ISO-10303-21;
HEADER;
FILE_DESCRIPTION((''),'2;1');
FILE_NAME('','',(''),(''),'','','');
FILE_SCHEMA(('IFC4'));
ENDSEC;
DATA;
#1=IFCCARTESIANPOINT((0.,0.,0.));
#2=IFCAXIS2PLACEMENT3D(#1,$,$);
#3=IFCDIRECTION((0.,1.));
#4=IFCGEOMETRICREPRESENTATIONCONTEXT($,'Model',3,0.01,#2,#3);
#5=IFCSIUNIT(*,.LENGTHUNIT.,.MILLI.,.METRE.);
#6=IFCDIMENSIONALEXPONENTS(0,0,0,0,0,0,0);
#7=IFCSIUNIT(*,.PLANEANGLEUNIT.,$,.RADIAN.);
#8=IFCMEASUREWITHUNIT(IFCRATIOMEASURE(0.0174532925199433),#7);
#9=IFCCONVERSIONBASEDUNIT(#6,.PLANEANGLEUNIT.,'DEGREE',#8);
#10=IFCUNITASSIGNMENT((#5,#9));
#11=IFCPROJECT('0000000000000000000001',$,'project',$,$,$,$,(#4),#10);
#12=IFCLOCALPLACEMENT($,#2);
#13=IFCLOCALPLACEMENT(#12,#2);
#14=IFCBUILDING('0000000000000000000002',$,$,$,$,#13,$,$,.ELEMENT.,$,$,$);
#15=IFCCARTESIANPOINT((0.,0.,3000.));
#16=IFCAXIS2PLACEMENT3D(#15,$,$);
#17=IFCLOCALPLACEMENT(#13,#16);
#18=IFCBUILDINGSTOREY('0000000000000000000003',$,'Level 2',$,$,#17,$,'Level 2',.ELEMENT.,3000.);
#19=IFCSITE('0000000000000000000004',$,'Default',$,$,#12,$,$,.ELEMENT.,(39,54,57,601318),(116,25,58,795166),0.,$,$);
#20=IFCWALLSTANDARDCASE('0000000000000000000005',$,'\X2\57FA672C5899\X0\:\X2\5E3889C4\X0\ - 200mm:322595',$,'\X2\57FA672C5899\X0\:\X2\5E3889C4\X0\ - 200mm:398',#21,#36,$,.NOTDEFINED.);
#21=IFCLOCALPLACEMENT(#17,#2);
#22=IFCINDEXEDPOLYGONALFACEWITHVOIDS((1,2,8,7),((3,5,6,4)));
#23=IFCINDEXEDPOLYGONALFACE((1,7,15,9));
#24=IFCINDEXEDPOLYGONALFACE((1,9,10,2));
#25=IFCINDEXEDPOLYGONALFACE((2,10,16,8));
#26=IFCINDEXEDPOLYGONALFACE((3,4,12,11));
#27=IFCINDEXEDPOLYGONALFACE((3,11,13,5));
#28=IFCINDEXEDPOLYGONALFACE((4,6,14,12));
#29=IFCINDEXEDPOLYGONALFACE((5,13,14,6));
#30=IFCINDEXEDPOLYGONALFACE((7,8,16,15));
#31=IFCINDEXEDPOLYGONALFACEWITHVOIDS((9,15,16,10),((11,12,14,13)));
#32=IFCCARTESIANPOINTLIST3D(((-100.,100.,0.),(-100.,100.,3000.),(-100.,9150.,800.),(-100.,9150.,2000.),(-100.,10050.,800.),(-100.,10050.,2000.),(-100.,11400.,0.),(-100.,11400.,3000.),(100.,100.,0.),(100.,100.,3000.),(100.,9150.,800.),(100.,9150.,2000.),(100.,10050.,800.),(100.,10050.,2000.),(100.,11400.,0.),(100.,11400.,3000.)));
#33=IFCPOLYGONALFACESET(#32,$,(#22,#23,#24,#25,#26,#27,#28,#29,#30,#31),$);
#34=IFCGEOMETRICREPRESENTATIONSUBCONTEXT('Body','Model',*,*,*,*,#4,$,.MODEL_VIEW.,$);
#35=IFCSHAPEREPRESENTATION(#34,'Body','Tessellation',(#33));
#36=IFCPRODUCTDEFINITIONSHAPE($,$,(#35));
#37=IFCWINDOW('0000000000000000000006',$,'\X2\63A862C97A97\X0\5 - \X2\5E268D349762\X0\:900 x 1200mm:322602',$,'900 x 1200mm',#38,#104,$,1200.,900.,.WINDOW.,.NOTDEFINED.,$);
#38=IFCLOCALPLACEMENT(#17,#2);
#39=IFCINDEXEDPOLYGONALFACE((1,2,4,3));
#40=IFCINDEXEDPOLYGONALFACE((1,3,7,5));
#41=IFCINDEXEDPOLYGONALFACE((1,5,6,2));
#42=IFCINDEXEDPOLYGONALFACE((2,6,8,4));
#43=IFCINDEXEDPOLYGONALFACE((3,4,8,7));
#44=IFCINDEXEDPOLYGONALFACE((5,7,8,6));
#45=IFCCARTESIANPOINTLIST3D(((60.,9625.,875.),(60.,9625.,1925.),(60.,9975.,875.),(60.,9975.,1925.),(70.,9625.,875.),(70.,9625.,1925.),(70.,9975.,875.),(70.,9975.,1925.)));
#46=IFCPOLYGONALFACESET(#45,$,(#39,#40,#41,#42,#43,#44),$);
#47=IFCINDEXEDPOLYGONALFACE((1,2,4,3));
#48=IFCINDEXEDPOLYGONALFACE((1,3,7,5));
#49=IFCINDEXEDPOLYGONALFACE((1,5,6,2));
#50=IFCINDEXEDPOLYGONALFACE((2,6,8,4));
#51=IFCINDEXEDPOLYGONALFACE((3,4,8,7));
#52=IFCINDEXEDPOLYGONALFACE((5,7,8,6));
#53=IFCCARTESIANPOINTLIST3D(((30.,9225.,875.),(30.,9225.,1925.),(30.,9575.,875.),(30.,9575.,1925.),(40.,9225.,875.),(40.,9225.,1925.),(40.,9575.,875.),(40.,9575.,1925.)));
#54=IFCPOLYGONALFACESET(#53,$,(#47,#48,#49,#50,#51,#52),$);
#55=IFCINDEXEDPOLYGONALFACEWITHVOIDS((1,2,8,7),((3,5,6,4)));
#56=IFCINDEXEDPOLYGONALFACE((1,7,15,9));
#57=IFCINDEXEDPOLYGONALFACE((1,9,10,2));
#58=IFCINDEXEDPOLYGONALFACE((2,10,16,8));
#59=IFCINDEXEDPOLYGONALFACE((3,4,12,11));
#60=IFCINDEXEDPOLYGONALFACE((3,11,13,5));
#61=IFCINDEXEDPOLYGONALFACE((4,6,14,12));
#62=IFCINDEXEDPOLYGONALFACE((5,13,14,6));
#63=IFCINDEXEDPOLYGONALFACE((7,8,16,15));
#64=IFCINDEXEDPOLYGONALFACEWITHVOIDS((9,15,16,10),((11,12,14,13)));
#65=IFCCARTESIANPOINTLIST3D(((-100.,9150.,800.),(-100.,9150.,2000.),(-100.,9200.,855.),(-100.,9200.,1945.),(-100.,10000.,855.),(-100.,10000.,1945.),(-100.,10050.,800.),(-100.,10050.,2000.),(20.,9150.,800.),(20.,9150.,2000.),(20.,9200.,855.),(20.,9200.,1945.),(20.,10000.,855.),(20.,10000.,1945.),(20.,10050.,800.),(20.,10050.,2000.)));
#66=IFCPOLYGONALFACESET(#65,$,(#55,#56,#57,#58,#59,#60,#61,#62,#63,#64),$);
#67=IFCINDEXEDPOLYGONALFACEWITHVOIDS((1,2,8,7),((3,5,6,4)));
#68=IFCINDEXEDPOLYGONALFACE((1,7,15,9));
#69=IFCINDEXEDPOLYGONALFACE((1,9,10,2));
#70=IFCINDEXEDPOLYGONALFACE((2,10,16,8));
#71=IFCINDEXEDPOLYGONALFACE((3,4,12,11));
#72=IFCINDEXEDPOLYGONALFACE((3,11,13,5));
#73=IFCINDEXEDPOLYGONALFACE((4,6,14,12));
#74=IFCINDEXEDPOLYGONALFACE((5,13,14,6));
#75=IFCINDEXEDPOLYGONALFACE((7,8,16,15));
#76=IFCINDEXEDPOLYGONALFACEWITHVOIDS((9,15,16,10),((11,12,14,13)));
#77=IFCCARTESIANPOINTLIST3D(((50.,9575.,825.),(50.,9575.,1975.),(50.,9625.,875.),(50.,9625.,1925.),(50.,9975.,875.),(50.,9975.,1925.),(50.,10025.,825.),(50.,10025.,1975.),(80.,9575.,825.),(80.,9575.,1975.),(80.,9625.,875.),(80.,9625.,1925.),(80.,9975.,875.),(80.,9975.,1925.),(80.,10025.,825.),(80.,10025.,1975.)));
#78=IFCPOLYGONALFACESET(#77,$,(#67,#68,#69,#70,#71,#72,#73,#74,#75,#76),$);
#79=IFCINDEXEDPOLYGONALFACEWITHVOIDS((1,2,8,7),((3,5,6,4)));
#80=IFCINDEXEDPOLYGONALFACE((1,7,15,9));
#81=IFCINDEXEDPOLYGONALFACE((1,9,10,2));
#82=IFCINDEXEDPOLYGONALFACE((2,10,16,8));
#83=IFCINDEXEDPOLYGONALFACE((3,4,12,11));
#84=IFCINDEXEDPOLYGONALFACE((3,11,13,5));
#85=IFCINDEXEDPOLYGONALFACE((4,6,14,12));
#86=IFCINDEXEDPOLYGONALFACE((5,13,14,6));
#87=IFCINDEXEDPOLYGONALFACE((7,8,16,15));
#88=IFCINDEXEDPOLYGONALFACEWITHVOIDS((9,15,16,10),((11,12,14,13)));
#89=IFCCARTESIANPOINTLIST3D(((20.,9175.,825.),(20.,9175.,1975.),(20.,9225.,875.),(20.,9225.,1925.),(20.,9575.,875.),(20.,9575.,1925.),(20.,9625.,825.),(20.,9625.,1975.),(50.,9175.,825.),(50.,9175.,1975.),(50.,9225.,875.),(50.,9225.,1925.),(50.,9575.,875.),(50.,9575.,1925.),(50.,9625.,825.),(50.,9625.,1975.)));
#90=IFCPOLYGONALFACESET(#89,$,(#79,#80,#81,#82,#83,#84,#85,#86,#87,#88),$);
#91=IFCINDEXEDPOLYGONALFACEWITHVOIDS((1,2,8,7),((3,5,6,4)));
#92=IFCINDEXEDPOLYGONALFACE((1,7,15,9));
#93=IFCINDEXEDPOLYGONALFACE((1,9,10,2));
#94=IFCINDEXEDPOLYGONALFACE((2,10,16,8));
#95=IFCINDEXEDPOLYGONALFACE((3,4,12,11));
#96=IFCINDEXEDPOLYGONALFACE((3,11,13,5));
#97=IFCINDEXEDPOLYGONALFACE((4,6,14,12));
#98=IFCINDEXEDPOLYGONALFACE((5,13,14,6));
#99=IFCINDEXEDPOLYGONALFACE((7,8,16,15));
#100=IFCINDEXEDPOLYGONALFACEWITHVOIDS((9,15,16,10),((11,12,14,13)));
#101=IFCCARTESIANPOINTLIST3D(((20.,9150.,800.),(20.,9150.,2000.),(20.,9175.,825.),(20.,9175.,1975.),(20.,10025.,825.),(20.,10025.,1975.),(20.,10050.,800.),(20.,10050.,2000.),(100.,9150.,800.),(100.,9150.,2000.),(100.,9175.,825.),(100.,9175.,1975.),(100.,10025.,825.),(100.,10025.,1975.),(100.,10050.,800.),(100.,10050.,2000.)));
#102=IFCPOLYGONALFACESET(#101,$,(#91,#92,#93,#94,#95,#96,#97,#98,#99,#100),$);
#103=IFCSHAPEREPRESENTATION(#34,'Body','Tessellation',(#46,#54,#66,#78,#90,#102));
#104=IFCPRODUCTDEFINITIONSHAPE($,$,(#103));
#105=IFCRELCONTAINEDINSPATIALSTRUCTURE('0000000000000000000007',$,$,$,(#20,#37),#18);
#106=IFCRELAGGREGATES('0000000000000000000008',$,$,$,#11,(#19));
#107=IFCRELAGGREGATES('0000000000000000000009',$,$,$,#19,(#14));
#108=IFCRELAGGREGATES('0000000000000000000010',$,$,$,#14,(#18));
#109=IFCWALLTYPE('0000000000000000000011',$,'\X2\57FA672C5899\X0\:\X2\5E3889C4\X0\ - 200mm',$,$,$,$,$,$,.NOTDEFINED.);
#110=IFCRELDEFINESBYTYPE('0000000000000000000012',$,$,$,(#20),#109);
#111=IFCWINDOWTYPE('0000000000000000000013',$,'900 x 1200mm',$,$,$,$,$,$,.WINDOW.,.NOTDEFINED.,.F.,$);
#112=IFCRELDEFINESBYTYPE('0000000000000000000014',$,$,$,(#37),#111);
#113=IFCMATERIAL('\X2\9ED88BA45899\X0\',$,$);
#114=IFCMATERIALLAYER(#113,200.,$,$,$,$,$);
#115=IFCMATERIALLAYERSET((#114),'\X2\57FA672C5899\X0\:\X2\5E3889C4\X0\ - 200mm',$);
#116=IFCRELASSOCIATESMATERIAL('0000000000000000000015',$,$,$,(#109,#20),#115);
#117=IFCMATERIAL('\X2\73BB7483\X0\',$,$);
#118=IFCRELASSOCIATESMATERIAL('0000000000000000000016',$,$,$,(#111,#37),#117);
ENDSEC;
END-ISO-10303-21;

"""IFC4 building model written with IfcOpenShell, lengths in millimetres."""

from ifc_helpers import new_model, entity, si_unit, converted_unit, direction, frame, frame_2d, origin, origin_2d_with_axis, place, context, subcontext, project, spatial, polyline, rectangle, outline, extrude, source, transform, mapped, material, layer, layer_set, layer_usage, type_object, type_shapes, element, fill, save


model = new_model("IFC4")

# Units and contexts
model_context = context("Model", 3, precision=0.01, world=origin(), true_north=direction((0.0, 1.0)))
body_context = subcontext(model_context, "Body", "Model", "MODEL_VIEW")
ifc_project = project(units=[si_unit("LENGTHUNIT", "METRE", prefix="MILLI"), converted_unit("PLANEANGLEUNIT", "DEGREE", entity("IfcRatioMeasure", 0.0174532925199433), si_unit("PLANEANGLEUNIT", "RADIAN"), dimensions=[0, 0, 0, 0, 0, 0, 0])], contexts=[model_context])

# Site, building, storey
site_placement = place(None, origin())
site = spatial("IfcSite", under=ifc_project, at=site_placement, Name="Default", CompositionType="ELEMENT", RefLatitude=(39, 54, 57, 601318), RefLongitude=(116, 25, 58, 795166), RefElevation=0.0)
building_placement = place(site_placement, origin())
building = spatial("IfcBuilding", under=site, at=building_placement, CompositionType="ELEMENT")
storey_placement = place(building_placement, frame((0.0, 0.0, 3000.0)))
storey = spatial("IfcBuildingStorey", under=building, at=storey_placement, Name="Level 2", LongName="Level 2", CompositionType="ELEMENT", Elevation=3000.0)

# Shared definitions
ifc_material_1 = material(Name="默认墙")
ifc_layer_1 = layer(ifc_material_1, 200.0)
ifc_layer_set_1 = layer_set([ifc_layer_1], Name="基本墙:常规 - 200mm")
wall_type = type_object("IfcWallType", Name="基本墙:常规 - 200mm", PredefinedType="NOTDEFINED", material=ifc_layer_set_1)

# Shared definitions
ifc_material_2 = material(Name="玻璃")
window_type_1 = type_object("IfcWindowType", Name="900 x 1200mm", ParameterTakesPrecedence=False, PartitioningType="NOTDEFINED", PredefinedType="WINDOW", material=ifc_material_2)
shared_shape_1 = source(origin(), body_context, "Body", "SweptSolid", [
    extrude(rectangle(XDim=10.0, YDim=350.0, at=origin_2d_with_axis()), frame((250.0, 165.0, 75.0), z_axis=(0.0, 0.0, 1.0), x_axis=(0.0, -1.0, 0.0)), (0.0, 0.0, 1.0), 1050.0),
    extrude(rectangle(XDim=10.0, YDim=350.0, at=origin_2d_with_axis()), frame((650.0, 135.0, 75.0), z_axis=(0.0, 0.0, 1.0), x_axis=(0.0, -1.0, 0.0)), (0.0, 0.0, 1.0), 1050.0),
    extrude(outline(polyline([(-450.0, -600.0), (450.0, -600.0), (450.0, 600.0), (-450.0, 600.0), (-450.0, -600.0)]), holes=[polyline([(400.0, -545.0), (-400.0, -545.0), (-400.0, 545.0), (400.0, 545.0), (400.0, -545.0)])]), frame((450.0, 0.0, 600.0), z_axis=(0.0, 1.0, 0.0), x_axis=(1.0, 0.0, 0.0)), (0.0, 0.0, 1.0), 120.0),
    extrude(outline(polyline([(-225.0, -575.0), (225.0, -575.0), (225.0, 575.0), (-225.0, 575.0), (-225.0, -575.0)]), holes=[polyline([(-175.0, -525.0), (-175.0, 525.0), (175.0, 525.0), (175.0, -525.0), (-175.0, -525.0)])]), frame((250.0, 150.0, 600.0), z_axis=(0.0, 1.0, 0.0), x_axis=(-1.0, 0.0, 0.0)), (0.0, 0.0, 1.0), 30.0),
    extrude(outline(polyline([(-225.0, -575.0), (225.0, -575.0), (225.0, 575.0), (-225.0, 575.0), (-225.0, -575.0)]), holes=[polyline([(-175.0, -525.0), (-175.0, 525.0), (175.0, 525.0), (175.0, -525.0), (-175.0, -525.0)])]), frame((650.0, 120.0, 600.0), z_axis=(0.0, 1.0, 0.0), x_axis=(1.0, 0.0, 0.0)), (0.0, 0.0, 1.0), 30.0),
    extrude(outline(polyline([(-450.0, -600.0), (450.0, -600.0), (450.0, 600.0), (-450.0, 600.0), (-450.0, -600.0)]), holes=[polyline([(-425.0, 575.0), (425.0, 575.0), (425.0, -575.0), (-425.0, -575.0), (-425.0, 575.0)])]), frame((450.0, 120.0, 600.0), z_axis=(0.0, 1.0, 0.0), x_axis=(1.0, 0.0, 0.0)), (0.0, 0.0, 1.0), 80.0),
])
type_shapes(window_type_1, [shared_shape_1])

# Wall, opening, window
ifc_layer_usage_1 = layer_usage(ifc_layer_set_1, "AXIS2", "NEGATIVE", 100.0)
wall_1_placement = place(storey_placement, frame((0.0, 100.0, 0.0), z_axis=(0.0, 0.0, 1.0), x_axis=(0.0, 1.0, 0.0)))
wall_1 = element("IfcWallStandardCase", 1, at=wall_1_placement, inside=storey, type_object=wall_type, material=ifc_layer_usage_1, Name="基本墙:常规 - 200mm:322595", ObjectType="基本墙:常规 - 200mm:398", PredefinedType="NOTDEFINED", context=body_context, shape_type="SweptSolid", body=[
    extrude(rectangle(XDim=11300.0, YDim=200.0, at=frame_2d((5650.0, 0.0), x_axis=(-1.0, 0.0))), origin(), (0.0, 0.0, 1.0), 3000.0),
])
opening_1_placement = place(wall_1_placement, frame((9950.0, 100.0, 800.0)))
opening_1 = element("IfcOpeningElement", 2, at=opening_1_placement, cuts=wall_1, ObjectType="Opening", PredefinedType="OPENING", context=body_context, shape_type="SweptSolid", body=[
    extrude(rectangle(XDim=1200.0, YDim=900.0, at=frame_2d((600.0, 450.0), x_axis=(-1.0, 0.0))), frame((0.0, 0.0, 0.0), z_axis=(0.0, -1.0, 0.0), x_axis=(0.0, 0.0, 1.0)), (0.0, 0.0, 1.0), 200.0),
])
window_1_placement = place(opening_1_placement, frame((0.0, 0.0, 0.0), z_axis=(0.0, 0.0, 1.0), x_axis=(-1.0, 0.0, 0.0)))
window_1 = element("IfcWindow", 3, at=window_1_placement, inside=storey, type_object=window_type_1, material=ifc_material_2, Name="推拉窗5 - 带贴面:900 x 1200mm:322602", ObjectType="900 x 1200mm", OverallHeight=1200.0, OverallWidth=900.0, PartitioningType="NOTDEFINED", PredefinedType="WINDOW", context=body_context, shape_type="MappedRepresentation", body=[
    mapped(shared_shape_1, transform((0.0, 0.0, 0.0), scale=1.0)),
])
fill(opening_1, window_1)

save(model, "model.ifc")
